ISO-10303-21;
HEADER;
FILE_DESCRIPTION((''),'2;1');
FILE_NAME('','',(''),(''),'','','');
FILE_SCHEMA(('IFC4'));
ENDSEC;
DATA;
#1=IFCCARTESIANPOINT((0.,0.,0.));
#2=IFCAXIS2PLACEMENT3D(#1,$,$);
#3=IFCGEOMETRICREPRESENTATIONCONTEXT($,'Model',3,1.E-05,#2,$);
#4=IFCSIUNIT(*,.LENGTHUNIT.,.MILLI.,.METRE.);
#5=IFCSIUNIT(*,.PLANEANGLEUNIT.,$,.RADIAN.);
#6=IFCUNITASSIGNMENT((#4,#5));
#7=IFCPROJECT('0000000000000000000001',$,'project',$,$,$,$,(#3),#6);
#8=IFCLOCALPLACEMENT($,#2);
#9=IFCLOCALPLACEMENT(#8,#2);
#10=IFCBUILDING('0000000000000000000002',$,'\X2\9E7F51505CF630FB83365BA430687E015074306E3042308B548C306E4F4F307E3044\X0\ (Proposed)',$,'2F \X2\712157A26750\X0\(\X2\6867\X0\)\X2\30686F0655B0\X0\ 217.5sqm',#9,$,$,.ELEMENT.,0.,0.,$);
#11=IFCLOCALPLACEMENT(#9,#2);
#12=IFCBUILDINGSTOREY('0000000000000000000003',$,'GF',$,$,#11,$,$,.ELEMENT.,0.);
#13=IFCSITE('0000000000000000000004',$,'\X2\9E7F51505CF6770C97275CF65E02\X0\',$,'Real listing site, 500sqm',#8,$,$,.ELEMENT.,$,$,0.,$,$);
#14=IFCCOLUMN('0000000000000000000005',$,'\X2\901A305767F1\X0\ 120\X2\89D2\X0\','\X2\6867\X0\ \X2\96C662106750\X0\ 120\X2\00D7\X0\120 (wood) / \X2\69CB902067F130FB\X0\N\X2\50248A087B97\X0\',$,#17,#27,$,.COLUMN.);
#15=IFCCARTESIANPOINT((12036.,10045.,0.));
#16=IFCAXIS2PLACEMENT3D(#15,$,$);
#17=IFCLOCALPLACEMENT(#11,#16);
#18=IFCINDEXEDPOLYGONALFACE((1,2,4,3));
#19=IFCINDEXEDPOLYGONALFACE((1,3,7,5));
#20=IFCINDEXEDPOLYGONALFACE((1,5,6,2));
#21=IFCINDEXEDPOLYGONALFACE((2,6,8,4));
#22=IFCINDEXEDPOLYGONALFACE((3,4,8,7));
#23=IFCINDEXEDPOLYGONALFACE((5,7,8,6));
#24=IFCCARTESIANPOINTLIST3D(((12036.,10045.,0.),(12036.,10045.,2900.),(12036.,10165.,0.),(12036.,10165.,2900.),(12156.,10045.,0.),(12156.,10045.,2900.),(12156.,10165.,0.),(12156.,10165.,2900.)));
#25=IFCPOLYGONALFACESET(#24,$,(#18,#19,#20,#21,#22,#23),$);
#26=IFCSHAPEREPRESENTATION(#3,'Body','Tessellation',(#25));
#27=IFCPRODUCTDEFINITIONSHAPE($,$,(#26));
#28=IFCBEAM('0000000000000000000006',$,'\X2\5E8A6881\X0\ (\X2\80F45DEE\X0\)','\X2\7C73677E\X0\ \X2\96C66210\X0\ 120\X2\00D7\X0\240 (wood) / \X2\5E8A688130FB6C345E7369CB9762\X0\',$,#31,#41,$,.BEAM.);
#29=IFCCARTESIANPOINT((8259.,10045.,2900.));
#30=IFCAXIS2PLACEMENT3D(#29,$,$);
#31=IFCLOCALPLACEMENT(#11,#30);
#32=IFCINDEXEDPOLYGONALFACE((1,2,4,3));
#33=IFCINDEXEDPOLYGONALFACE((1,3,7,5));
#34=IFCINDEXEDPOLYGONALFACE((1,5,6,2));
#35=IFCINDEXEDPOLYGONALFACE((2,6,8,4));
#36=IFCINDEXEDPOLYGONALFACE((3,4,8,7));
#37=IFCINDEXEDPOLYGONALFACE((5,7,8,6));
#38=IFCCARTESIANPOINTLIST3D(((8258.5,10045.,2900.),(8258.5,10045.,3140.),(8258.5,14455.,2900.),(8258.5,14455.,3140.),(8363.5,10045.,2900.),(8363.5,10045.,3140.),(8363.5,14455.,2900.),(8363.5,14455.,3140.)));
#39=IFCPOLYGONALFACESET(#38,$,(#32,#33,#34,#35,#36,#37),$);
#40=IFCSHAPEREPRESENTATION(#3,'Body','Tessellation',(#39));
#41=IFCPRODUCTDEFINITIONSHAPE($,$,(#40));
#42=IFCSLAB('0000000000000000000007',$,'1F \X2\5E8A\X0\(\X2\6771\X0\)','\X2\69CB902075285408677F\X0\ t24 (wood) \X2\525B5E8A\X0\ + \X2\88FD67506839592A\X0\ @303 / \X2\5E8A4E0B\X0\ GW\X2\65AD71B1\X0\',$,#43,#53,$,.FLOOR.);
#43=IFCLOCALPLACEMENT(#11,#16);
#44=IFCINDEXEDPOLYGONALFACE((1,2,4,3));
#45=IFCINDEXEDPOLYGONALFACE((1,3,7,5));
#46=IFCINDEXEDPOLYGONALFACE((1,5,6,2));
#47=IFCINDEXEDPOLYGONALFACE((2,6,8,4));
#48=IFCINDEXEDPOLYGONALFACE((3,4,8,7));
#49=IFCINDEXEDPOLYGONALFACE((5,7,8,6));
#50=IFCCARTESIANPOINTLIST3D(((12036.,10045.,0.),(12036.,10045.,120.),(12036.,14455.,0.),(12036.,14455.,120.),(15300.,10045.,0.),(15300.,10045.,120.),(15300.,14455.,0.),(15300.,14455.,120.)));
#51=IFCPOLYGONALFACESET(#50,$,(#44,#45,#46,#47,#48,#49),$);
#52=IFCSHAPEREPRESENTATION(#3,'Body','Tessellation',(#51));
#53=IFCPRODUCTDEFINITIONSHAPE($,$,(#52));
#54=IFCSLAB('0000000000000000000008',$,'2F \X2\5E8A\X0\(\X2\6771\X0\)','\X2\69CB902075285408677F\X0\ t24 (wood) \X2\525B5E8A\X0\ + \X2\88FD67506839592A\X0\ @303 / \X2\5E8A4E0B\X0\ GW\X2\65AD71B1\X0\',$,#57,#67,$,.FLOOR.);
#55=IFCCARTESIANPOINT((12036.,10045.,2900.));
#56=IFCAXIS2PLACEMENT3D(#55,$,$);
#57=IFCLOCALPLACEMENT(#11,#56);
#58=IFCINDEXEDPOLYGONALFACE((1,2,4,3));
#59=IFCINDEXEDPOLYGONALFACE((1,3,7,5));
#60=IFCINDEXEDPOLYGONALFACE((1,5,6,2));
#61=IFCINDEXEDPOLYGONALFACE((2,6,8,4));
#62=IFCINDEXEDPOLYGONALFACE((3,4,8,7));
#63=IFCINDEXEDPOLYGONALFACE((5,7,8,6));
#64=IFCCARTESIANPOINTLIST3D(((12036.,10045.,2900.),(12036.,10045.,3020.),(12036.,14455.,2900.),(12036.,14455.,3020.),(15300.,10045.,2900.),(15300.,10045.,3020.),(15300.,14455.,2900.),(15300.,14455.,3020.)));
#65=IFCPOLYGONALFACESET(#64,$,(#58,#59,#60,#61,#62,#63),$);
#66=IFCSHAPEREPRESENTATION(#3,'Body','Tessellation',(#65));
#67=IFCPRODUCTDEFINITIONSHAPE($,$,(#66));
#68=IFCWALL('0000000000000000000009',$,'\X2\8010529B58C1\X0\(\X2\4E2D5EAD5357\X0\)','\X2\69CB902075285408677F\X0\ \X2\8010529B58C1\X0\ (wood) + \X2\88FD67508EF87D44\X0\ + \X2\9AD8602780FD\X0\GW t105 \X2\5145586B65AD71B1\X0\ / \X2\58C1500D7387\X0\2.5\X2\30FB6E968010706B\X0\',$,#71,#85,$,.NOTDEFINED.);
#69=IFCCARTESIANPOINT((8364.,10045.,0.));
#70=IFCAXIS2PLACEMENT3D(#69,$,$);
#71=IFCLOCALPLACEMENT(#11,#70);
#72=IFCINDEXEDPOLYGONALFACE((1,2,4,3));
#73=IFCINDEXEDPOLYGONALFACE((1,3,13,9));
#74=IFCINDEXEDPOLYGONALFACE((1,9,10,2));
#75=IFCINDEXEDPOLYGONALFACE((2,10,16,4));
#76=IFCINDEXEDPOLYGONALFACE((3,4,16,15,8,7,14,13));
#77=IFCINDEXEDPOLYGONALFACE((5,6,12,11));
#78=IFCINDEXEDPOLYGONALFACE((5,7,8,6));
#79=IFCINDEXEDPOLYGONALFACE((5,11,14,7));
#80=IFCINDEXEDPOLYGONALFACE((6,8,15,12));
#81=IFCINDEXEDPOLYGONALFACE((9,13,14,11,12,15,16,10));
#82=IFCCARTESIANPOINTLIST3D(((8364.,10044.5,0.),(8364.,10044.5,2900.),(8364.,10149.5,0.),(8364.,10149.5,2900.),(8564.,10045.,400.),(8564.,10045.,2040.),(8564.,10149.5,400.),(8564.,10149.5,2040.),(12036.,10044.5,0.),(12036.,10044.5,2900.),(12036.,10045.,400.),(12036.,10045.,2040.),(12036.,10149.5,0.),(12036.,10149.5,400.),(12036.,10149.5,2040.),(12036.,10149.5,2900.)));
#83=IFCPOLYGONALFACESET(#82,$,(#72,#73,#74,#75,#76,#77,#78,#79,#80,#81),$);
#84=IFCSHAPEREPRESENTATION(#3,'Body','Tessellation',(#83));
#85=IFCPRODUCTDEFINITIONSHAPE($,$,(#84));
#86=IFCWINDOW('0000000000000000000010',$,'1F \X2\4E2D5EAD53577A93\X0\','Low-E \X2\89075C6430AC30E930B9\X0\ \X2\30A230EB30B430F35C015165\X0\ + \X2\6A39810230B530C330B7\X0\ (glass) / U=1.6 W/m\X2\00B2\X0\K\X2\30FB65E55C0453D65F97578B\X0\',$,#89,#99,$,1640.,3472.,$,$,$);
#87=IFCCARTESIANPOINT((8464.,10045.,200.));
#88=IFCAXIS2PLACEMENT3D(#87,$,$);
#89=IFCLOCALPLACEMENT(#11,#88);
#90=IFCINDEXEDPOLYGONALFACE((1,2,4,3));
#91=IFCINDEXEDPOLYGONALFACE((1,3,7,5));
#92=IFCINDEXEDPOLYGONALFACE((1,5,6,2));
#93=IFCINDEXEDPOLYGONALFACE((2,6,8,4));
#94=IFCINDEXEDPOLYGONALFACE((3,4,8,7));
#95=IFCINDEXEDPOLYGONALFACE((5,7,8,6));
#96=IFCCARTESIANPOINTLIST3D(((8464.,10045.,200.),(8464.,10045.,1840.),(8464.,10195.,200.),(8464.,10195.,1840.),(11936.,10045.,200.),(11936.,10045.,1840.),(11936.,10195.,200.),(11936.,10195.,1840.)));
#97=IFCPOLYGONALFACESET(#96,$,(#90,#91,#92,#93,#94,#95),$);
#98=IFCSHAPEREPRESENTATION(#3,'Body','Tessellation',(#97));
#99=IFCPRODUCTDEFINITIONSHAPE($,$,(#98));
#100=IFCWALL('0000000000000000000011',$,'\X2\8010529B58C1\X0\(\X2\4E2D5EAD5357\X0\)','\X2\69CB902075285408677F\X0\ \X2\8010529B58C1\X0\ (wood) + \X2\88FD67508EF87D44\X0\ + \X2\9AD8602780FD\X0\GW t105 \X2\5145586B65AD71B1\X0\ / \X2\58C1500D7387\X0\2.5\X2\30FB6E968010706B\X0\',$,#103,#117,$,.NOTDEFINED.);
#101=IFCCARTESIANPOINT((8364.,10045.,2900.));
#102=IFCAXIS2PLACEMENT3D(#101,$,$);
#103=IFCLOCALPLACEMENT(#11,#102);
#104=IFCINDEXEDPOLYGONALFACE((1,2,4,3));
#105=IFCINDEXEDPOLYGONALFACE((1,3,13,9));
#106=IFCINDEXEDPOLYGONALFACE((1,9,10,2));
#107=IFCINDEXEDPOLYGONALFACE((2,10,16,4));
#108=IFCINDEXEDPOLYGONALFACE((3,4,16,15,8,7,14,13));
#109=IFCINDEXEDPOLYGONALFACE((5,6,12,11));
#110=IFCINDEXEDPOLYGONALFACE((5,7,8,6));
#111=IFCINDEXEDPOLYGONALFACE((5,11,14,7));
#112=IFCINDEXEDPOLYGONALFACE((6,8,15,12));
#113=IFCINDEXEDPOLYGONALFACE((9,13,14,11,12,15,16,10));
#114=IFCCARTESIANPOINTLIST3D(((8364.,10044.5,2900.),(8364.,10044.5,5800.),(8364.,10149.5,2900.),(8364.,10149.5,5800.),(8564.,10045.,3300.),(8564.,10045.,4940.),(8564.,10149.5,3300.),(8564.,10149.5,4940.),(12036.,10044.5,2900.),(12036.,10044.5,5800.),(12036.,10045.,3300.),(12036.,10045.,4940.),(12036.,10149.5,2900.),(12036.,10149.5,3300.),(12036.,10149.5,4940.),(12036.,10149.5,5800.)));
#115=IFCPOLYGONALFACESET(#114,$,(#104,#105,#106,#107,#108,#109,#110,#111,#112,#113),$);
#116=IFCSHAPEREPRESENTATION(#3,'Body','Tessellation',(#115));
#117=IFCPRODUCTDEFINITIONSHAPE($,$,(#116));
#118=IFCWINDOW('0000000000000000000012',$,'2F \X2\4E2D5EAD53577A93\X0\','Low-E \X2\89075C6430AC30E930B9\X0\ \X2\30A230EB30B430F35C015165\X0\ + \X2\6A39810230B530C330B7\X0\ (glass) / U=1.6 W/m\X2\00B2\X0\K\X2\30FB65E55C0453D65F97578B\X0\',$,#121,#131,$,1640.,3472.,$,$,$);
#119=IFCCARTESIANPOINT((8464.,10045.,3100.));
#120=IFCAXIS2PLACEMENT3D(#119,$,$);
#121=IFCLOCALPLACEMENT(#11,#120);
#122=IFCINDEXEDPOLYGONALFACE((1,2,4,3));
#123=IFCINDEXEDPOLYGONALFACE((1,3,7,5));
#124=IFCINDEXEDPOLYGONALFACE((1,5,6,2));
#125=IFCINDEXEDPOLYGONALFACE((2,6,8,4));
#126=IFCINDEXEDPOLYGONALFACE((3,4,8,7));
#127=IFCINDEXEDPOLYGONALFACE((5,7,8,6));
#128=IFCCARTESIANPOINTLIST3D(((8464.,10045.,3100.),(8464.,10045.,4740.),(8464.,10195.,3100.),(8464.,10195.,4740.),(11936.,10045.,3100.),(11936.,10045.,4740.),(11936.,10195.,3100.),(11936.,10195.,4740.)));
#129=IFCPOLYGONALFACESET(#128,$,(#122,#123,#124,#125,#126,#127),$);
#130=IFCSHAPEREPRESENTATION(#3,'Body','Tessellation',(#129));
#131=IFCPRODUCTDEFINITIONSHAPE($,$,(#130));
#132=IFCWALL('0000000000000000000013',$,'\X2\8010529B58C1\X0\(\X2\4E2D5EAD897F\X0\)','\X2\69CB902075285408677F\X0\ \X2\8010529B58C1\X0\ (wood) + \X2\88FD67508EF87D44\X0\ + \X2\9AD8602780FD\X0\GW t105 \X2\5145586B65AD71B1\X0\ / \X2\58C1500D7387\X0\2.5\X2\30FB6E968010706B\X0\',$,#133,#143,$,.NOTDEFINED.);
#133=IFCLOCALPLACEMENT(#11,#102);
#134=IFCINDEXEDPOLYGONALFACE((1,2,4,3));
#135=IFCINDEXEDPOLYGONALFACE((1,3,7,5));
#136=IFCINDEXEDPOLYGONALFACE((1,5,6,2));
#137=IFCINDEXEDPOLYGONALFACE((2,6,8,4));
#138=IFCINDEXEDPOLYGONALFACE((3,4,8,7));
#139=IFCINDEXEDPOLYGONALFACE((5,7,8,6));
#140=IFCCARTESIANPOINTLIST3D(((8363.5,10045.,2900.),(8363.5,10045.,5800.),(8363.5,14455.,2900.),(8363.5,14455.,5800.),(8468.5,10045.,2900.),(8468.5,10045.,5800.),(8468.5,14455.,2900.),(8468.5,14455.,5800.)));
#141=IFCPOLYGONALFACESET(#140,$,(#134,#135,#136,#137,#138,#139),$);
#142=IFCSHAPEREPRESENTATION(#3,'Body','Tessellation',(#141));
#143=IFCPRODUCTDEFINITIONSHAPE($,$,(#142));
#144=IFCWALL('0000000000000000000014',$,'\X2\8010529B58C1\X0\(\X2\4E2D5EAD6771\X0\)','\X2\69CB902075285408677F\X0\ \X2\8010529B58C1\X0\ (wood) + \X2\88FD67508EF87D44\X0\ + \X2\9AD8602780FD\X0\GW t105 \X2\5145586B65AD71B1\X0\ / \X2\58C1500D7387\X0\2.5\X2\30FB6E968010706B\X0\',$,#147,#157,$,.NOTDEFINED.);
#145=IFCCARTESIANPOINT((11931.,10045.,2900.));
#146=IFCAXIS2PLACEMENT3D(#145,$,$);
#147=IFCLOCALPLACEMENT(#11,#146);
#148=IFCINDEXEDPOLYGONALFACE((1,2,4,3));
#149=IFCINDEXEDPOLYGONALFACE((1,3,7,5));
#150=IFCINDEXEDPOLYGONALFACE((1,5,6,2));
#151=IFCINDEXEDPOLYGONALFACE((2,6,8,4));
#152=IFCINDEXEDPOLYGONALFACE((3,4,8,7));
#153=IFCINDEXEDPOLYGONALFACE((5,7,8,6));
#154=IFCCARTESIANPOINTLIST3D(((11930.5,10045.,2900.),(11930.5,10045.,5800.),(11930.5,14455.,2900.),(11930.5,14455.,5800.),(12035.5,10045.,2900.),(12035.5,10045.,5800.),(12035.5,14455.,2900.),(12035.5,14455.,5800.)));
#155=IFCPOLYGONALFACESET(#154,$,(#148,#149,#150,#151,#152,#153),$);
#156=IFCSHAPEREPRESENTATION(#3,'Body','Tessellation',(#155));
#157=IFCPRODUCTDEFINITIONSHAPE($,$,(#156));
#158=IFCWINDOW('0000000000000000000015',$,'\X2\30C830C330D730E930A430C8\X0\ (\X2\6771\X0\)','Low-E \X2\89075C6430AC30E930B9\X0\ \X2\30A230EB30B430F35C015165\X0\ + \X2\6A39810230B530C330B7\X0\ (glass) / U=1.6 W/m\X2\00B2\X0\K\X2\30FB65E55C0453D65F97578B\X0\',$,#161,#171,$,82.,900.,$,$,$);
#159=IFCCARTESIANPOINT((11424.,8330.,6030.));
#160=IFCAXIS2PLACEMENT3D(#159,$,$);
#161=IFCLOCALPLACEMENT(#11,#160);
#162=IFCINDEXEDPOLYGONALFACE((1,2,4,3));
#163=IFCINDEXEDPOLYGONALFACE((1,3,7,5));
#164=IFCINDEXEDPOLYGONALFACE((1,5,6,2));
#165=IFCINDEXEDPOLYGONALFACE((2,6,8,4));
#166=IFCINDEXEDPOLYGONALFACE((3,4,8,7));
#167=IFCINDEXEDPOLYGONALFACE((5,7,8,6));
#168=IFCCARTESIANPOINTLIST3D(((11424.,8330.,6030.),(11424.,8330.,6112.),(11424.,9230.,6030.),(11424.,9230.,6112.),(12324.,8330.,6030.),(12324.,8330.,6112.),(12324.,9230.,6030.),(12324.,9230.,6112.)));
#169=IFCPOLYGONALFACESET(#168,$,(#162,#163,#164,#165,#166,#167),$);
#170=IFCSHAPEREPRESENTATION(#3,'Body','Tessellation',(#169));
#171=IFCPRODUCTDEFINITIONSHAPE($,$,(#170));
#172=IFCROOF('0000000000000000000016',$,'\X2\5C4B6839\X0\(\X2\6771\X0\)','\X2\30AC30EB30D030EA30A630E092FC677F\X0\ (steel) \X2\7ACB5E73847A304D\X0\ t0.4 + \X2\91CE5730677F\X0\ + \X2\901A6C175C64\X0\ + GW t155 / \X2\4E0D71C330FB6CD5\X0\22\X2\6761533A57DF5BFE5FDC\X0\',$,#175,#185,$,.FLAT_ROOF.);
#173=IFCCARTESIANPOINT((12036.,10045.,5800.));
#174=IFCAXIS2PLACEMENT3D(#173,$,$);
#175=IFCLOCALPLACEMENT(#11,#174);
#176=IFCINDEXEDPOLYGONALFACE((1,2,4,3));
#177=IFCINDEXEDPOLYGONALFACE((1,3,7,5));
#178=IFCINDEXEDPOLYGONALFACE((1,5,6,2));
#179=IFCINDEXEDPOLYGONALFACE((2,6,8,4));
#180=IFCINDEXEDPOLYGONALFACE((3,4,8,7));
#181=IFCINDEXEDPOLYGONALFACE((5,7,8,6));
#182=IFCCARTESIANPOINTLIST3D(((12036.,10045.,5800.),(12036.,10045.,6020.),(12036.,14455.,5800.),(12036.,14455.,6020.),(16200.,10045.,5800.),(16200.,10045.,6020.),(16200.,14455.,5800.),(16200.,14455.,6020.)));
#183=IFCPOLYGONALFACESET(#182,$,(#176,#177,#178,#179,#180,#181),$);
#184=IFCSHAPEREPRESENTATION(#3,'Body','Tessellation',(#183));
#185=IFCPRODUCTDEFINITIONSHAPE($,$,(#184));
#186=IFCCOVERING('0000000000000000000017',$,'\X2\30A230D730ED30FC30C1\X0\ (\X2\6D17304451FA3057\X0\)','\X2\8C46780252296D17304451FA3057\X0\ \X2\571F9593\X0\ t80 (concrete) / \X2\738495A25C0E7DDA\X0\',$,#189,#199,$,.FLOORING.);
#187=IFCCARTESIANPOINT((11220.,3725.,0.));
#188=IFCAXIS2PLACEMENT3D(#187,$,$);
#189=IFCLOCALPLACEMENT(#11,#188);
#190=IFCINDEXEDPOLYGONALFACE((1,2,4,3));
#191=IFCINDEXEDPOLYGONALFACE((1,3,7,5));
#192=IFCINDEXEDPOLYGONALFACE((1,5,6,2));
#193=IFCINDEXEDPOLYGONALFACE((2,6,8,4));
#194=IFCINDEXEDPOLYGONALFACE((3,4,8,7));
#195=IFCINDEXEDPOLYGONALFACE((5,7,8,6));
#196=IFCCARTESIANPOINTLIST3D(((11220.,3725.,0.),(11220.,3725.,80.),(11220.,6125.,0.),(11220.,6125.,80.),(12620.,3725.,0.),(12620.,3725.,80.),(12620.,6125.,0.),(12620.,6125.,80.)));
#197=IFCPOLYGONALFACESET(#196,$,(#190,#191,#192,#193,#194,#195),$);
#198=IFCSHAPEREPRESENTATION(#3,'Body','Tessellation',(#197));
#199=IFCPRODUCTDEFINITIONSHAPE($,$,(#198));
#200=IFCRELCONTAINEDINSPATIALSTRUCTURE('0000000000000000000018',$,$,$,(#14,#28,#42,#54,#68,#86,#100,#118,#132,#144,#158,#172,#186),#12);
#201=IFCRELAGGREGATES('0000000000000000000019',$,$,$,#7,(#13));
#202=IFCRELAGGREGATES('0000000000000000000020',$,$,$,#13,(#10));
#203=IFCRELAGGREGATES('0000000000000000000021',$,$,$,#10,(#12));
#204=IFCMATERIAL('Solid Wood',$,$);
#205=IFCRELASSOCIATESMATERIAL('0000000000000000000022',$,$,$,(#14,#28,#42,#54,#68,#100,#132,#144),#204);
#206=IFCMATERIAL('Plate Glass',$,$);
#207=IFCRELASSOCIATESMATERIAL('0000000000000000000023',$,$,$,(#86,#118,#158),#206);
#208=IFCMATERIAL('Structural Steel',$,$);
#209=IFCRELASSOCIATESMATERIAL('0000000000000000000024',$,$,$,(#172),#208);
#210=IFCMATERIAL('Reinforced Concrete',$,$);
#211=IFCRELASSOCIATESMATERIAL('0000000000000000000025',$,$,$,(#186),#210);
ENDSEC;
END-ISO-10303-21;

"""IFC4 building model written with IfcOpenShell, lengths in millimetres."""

from ifc_helpers import new_model, si_unit, frame, frame_2d, origin, place, context, project, spatial, rectangle, extrude, material, element, fill, save


model = new_model("IFC4")

# Units and contexts
model_context = context("Model", 3, precision=1e-05, world=origin())
ifc_project = project(units=[si_unit("LENGTHUNIT", "METRE", prefix="MILLI"), si_unit("PLANEANGLEUNIT", "RADIAN")], contexts=[model_context])

# Site, building, storey
site_placement = place(None, origin())
site = spatial("IfcSite", under=ifc_project, at=site_placement, Name="鹿児島県霧島市", ObjectType="Real listing site, 500sqm", CompositionType="ELEMENT", RefElevation=0.0)
building_placement = place(site_placement, origin())
building = spatial("IfcBuilding", under=site, at=building_placement, Name="鹿児島・茶室と縁側のある和の住まい (Proposed)", ObjectType="2F 無垢材(桧)と漆喰 217.5sqm", CompositionType="ELEMENT", ElevationOfRefHeight=0.0, ElevationOfTerrain=0.0)
storey_placement = place(building_placement, origin())
storey = spatial("IfcBuildingStorey", under=building, at=storey_placement, Name="GF", CompositionType="ELEMENT", Elevation=0.0)

# Column
ifc_material_1 = material(Name="Solid Wood")
column_1_placement = place(storey_placement, frame((12036.0, 10045.0, 0.0)))
element("IfcColumn", 1, at=column_1_placement, inside=storey, material=ifc_material_1, Name="通し柱 120角", Description="桧 集成材 120×120 (wood) / 構造柱・N値計算", PredefinedType="COLUMN", context=model_context, shape_type="SweptSolid", body=[
    extrude(rectangle(XDim=120.0, YDim=120.0, at=frame_2d((60.0, 60.0))), frame((12036.0, 10045.0, 0.0)), (0.0, 0.0, 1.0), 2900.0),
])

# Beam
beam_placement = place(storey_placement, frame((8259.0, 10045.0, 2900.0)))
element("IfcBeam", 2, at=beam_placement, inside=storey, material=ifc_material_1, Name="床梁 (胴差)", Description="米松 集成 120×240 (wood) / 床梁・水平構面", PredefinedType="BEAM", context=model_context, shape_type="SweptSolid", body=[
    extrude(rectangle(XDim=105.0, YDim=4410.0, at=frame_2d((52.0, 2205.0))), frame((8259.0, 10045.0, 2900.0)), (0.0, 0.0, 1.0), 240.0),
])

# Slabs
slab_1_placement = place(storey_placement, frame((12036.0, 10045.0, 0.0)))
element("IfcSlab", 3, at=slab_1_placement, inside=storey, material=ifc_material_1, Name="1F 床(東)", Description="構造用合板 t24 (wood) 剛床 + 製材根太 @303 / 床下 GW断熱", PredefinedType="FLOOR", context=model_context, shape_type="SweptSolid", body=[
    extrude(rectangle(XDim=3264.0, YDim=4410.0, at=frame_2d((1632.0, 2205.0))), frame((12036.0, 10045.0, 0.0)), (0.0, 0.0, 1.0), 120.0),
])
slab_2_placement = place(storey_placement, frame((12036.0, 10045.0, 2900.0)))
element("IfcSlab", 4, at=slab_2_placement, inside=storey, material=ifc_material_1, Name="2F 床(東)", Description="構造用合板 t24 (wood) 剛床 + 製材根太 @303 / 床下 GW断熱", PredefinedType="FLOOR", context=model_context, shape_type="SweptSolid", body=[
    extrude(rectangle(XDim=3264.0, YDim=4410.0, at=frame_2d((1632.0, 2205.0))), frame((12036.0, 10045.0, 2900.0)), (0.0, 0.0, 1.0), 120.0),
])

# Wall, opening, window
wall_1_placement = place(storey_placement, frame((8364.0, 10045.0, 0.0)))
wall_1 = element("IfcWall", 5, at=wall_1_placement, inside=storey, material=ifc_material_1, Name="耐力壁(中庭南)", Description="構造用合板 耐力壁 (wood) + 製材軸組 + 高性能GW t105 充填断熱 / 壁倍率2.5・準耐火", PredefinedType="NOTDEFINED", context=model_context, shape_type="SweptSolid", body=[
    extrude(rectangle(XDim=3672.0, YDim=105.0, at=frame_2d((1836.0, 52.0))), frame((8364.0, 10045.0, 0.0)), (0.0, 0.0, 1.0), 2900.0),
])
opening_1_placement = place(storey_placement, frame((8464.0, 10045.0, 200.0)))
opening_1 = element("IfcOpeningElement", 6, at=opening_1_placement, cuts=wall_1, PredefinedType="NOTDEFINED", context=model_context, shape_type="SweptSolid", body=[
    extrude(rectangle(XDim=3472.0, YDim=150.0, at=frame_2d((1736.0, 75.0))), frame((8464.0, 10045.0, 200.0)), (0.0, 0.0, 1.0), 1640.0),
])
ifc_material_2 = material(Name="Plate Glass")
window_1_placement = place(storey_placement, frame((8464.0, 10045.0, 200.0)))
window_1 = element("IfcWindow", 7, at=window_1_placement, inside=storey, material=ifc_material_2, Name="1F 中庭南窓", Description="Low-E 複層ガラス アルゴン封入 + 樹脂サッシ (glass) / U=1.6 W/m²K・日射取得型", OverallHeight=1640.0, OverallWidth=3472.0, context=model_context, shape_type="SweptSolid", body=[
    extrude(rectangle(XDim=3472.0, YDim=150.0, at=frame_2d((1736.0, 75.0))), frame((8464.0, 10045.0, 200.0)), (0.0, 0.0, 1.0), 1640.0),
])
fill(opening_1, window_1)

# Wall, opening, window
wall_2_placement = place(storey_placement, frame((8364.0, 10045.0, 2900.0)))
wall_2 = element("IfcWall", 8, at=wall_2_placement, inside=storey, material=ifc_material_1, Name="耐力壁(中庭南)", Description="構造用合板 耐力壁 (wood) + 製材軸組 + 高性能GW t105 充填断熱 / 壁倍率2.5・準耐火", PredefinedType="NOTDEFINED", context=model_context, shape_type="SweptSolid", body=[
    extrude(rectangle(XDim=3672.0, YDim=105.0, at=frame_2d((1836.0, 52.0))), frame((8364.0, 10045.0, 2900.0)), (0.0, 0.0, 1.0), 2900.0),
])
opening_2_placement = place(storey_placement, frame((8464.0, 10045.0, 3100.0)))
opening_2 = element("IfcOpeningElement", 9, at=opening_2_placement, cuts=wall_2, PredefinedType="NOTDEFINED", context=model_context, shape_type="SweptSolid", body=[
    extrude(rectangle(XDim=3472.0, YDim=150.0, at=frame_2d((1736.0, 75.0))), frame((8464.0, 10045.0, 3100.0)), (0.0, 0.0, 1.0), 1640.0),
])
window_2_placement = place(storey_placement, frame((8464.0, 10045.0, 3100.0)))
window_2 = element("IfcWindow", 10, at=window_2_placement, inside=storey, material=ifc_material_2, Name="2F 中庭南窓", Description="Low-E 複層ガラス アルゴン封入 + 樹脂サッシ (glass) / U=1.6 W/m²K・日射取得型", OverallHeight=1640.0, OverallWidth=3472.0, context=model_context, shape_type="SweptSolid", body=[
    extrude(rectangle(XDim=3472.0, YDim=150.0, at=frame_2d((1736.0, 75.0))), frame((8464.0, 10045.0, 3100.0)), (0.0, 0.0, 1.0), 1640.0),
])
fill(opening_2, window_2)

# Walls
wall_3_placement = place(storey_placement, frame((8364.0, 10045.0, 2900.0)))
element("IfcWall", 11, at=wall_3_placement, inside=storey, material=ifc_material_1, Name="耐力壁(中庭西)", Description="構造用合板 耐力壁 (wood) + 製材軸組 + 高性能GW t105 充填断熱 / 壁倍率2.5・準耐火", PredefinedType="NOTDEFINED", context=model_context, shape_type="SweptSolid", body=[
    extrude(rectangle(XDim=105.0, YDim=4410.0, at=frame_2d((52.0, 2205.0))), frame((8364.0, 10045.0, 2900.0)), (0.0, 0.0, 1.0), 2900.0),
])
wall_4_placement = place(storey_placement, frame((11931.0, 10045.0, 2900.0)))
element("IfcWall", 12, at=wall_4_placement, inside=storey, material=ifc_material_1, Name="耐力壁(中庭東)", Description="構造用合板 耐力壁 (wood) + 製材軸組 + 高性能GW t105 充填断熱 / 壁倍率2.5・準耐火", PredefinedType="NOTDEFINED", context=model_context, shape_type="SweptSolid", body=[
    extrude(rectangle(XDim=105.0, YDim=4410.0, at=frame_2d((52.0, 2205.0))), frame((11931.0, 10045.0, 2900.0)), (0.0, 0.0, 1.0), 2900.0),
])

# Window
window_3_placement = place(storey_placement, frame((11424.0, 8330.0, 6030.0)))
element("IfcWindow", 13, at=window_3_placement, inside=storey, material=ifc_material_2, Name="トップライト (東)", Description="Low-E 複層ガラス アルゴン封入 + 樹脂サッシ (glass) / U=1.6 W/m²K・日射取得型", OverallHeight=82.0, OverallWidth=900.0, context=model_context, shape_type="SweptSolid", body=[
    extrude(rectangle(XDim=900.0, YDim=900.0, at=frame_2d((450.0, 450.0))), frame((11424.0, 8330.0, 6030.0)), (0.0, 0.0, 1.0), 82.0),
])

# Roof
ifc_material_3 = material(Name="Structural Steel")
for number, where, name in (
    (14, (12036.0, 10045.0, 5800.0), "屋根(東)"),
):
    element("IfcRoof", number, at=place(storey_placement, frame(where)), inside=storey, material=ifc_material_3, Name=name, Description="ガルバリウム鋼板 (steel) 立平葺き t0.4 + 野地板 + 通気層 + GW t155 / 不燃・法22条区域対応", PredefinedType="FLAT_ROOF", context=model_context, shape_type="SweptSolid", body=[
        extrude(rectangle(XDim=4164.0, YDim=4410.0, at=frame_2d((2082.0, 2205.0))), frame((12036.0, 10045.0, 5800.0)), (0.0, 0.0, 1.0), 220.0),
    ])

# Covering
ifc_material_4 = material(Name="Reinforced Concrete")
covering_placement = place(storey_placement, frame((11220.0, 3725.0, 0.0)))
element("IfcCovering", 15, at=covering_placement, inside=storey, material=ifc_material_4, Name="アプローチ (洗い出し)", Description="豆砂利洗い出し 土間 t80 (concrete) / 玄関導線", PredefinedType="FLOORING", context=model_context, shape_type="SweptSolid", body=[
    extrude(rectangle(XDim=1400.0, YDim=2400.0, at=frame_2d((700.0, 1200.0))), frame((11220.0, 3725.0, 0.0)), (0.0, 0.0, 1.0), 80.0),
])

save(model, "model.ifc")
